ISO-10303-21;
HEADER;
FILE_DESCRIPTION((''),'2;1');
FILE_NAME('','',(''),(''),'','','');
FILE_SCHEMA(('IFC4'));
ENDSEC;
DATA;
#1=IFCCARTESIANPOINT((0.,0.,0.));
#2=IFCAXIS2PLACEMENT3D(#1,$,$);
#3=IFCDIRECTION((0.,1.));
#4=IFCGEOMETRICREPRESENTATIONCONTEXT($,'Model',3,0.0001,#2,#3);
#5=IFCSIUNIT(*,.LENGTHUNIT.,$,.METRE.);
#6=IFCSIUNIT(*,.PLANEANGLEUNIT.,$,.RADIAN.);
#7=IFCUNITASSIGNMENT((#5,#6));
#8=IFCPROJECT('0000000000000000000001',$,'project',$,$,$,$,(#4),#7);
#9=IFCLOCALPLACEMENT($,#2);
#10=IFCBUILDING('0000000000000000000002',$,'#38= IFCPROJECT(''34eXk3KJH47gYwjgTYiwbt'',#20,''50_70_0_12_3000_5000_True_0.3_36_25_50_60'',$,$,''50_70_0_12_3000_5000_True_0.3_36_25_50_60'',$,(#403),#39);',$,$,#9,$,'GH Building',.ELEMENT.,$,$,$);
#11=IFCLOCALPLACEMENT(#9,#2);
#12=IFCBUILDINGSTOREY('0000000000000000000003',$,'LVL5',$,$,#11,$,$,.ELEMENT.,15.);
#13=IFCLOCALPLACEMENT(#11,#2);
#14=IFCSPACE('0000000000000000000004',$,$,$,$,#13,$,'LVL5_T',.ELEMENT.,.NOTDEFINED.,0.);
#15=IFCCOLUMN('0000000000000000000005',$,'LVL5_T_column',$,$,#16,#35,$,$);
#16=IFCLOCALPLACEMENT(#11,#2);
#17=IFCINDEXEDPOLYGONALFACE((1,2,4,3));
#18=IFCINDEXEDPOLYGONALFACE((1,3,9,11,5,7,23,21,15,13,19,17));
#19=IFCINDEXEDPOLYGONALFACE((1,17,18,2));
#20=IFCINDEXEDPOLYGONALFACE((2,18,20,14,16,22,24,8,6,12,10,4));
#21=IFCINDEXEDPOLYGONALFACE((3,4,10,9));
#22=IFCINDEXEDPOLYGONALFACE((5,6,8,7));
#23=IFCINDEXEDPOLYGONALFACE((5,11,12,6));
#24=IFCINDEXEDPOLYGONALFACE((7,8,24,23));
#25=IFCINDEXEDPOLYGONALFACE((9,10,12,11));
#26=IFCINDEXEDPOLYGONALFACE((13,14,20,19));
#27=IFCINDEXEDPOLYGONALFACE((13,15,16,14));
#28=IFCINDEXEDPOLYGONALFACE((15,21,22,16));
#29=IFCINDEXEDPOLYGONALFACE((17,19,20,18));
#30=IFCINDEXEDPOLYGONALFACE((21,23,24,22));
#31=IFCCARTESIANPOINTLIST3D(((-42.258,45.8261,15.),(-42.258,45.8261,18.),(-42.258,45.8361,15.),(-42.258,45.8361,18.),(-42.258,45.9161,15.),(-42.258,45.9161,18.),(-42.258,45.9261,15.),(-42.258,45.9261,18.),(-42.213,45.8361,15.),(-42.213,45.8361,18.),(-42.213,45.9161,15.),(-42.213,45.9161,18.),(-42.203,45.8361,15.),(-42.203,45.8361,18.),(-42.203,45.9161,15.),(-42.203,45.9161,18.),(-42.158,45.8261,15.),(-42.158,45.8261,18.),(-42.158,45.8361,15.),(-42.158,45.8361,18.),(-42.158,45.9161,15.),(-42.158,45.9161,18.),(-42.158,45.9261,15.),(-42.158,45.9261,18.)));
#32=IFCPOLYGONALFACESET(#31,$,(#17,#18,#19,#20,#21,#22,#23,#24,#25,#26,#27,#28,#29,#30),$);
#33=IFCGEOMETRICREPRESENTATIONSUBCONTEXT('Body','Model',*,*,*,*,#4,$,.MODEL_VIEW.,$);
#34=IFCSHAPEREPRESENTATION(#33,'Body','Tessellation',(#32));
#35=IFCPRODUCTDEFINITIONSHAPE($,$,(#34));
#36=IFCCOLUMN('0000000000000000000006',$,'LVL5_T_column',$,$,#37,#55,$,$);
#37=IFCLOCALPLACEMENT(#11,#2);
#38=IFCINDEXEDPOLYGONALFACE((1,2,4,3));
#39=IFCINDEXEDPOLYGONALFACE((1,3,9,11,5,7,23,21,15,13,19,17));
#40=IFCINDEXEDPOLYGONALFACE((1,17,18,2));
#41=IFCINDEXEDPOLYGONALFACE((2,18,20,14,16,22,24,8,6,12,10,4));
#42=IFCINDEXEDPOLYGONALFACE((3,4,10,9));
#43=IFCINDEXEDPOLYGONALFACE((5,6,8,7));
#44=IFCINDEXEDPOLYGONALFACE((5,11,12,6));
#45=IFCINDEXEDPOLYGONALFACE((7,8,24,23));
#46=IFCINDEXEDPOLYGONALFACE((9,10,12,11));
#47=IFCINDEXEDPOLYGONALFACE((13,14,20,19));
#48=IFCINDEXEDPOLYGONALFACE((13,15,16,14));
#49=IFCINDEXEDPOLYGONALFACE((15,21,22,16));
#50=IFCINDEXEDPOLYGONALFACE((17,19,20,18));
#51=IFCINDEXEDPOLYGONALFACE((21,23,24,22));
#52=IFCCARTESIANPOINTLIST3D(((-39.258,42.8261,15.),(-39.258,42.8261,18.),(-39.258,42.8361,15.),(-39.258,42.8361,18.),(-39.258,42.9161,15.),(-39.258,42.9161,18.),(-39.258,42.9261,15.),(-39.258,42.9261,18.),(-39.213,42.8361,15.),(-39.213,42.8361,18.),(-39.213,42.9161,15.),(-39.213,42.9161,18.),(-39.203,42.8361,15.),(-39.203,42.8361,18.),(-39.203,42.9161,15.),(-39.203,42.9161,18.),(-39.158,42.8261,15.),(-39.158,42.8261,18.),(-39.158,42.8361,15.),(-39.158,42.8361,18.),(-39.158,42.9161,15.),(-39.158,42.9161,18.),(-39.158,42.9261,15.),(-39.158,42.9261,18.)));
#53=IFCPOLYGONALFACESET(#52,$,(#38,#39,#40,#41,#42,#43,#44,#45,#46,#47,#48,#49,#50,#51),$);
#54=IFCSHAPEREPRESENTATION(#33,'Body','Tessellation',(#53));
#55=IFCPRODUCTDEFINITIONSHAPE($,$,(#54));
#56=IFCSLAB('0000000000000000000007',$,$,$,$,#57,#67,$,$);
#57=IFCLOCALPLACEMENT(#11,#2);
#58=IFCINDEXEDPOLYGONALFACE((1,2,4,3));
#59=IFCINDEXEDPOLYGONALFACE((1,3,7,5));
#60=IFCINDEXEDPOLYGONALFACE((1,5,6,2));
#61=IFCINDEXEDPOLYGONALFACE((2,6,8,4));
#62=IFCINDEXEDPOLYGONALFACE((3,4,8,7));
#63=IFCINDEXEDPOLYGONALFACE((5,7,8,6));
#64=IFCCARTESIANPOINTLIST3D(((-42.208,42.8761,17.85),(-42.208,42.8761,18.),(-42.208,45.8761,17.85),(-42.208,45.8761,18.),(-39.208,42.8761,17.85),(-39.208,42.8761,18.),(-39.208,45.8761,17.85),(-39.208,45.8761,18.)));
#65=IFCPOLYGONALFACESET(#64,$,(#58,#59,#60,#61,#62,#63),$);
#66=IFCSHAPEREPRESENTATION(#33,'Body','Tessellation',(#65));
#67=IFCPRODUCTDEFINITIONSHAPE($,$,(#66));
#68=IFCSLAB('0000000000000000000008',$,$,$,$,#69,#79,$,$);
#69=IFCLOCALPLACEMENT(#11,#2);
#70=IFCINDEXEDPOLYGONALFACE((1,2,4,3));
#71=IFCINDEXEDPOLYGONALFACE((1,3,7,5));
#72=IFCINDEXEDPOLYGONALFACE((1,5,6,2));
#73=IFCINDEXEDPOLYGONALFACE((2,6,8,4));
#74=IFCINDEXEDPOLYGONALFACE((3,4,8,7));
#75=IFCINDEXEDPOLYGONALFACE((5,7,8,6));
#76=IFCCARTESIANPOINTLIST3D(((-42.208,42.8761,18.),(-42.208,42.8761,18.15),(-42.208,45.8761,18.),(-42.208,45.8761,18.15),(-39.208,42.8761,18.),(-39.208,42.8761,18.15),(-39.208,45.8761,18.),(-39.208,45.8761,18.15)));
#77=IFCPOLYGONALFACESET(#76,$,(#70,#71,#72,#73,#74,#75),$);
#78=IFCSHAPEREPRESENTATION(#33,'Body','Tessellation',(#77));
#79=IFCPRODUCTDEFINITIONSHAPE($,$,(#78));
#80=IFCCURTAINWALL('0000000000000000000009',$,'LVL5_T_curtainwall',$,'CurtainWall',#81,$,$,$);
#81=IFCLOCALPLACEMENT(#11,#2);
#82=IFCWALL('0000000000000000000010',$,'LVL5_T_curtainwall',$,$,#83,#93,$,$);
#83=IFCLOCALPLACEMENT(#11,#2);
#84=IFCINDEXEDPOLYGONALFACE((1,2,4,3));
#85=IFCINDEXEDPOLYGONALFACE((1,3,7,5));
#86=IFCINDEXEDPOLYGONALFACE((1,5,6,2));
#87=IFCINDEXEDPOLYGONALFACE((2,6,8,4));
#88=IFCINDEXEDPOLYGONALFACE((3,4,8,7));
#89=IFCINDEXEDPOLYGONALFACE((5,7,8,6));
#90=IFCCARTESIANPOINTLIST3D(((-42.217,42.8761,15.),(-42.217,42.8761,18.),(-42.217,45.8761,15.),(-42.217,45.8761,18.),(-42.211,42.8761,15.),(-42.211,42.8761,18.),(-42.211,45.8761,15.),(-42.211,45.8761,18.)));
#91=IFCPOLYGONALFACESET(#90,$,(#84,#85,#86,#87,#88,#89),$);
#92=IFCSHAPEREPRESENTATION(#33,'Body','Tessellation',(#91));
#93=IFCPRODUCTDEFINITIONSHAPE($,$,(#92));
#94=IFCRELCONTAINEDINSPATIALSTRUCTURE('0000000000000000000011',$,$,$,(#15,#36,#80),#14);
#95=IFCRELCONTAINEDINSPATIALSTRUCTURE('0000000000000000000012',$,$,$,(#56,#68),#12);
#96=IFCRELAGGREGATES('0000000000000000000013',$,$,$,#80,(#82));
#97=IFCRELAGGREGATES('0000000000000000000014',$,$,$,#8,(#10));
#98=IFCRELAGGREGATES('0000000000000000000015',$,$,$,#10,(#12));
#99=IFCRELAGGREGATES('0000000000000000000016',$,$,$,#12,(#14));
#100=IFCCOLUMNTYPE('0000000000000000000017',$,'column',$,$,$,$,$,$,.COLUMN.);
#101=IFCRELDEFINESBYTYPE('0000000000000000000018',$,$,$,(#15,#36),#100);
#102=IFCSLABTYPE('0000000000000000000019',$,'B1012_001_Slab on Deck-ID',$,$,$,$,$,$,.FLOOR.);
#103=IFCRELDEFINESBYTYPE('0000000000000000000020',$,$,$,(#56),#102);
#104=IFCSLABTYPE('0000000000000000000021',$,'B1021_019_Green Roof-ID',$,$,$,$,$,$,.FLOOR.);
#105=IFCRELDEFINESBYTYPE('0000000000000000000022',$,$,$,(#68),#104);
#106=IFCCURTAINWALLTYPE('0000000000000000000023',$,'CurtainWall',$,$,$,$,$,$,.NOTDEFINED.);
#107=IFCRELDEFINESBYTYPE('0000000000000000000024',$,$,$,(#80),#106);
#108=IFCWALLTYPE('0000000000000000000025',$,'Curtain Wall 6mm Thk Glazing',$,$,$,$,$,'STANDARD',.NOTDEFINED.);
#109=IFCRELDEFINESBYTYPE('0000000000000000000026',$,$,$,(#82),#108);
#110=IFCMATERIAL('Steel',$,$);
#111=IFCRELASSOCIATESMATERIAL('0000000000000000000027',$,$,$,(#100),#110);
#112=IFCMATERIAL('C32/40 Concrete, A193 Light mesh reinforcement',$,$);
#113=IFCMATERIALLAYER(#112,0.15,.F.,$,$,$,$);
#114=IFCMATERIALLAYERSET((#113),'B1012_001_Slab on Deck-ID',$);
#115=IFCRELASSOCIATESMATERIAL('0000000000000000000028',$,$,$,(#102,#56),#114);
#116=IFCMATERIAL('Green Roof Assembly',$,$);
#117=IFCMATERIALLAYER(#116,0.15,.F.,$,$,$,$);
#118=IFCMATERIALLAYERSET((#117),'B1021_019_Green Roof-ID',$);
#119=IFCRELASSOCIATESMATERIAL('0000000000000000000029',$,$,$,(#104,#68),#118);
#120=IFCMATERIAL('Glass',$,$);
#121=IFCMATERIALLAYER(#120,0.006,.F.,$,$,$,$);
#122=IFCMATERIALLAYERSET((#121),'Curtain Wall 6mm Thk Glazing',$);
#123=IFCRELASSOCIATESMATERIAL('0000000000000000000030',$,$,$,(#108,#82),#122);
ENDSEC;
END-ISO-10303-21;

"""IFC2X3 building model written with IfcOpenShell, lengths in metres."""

from ifc_helpers import new_model, si_unit, direction, frame, frame_2d, origin, origin_2d, place, context, subcontext, project, spatial, polyline, rectangle, i_section, outline, extrude, material, layer, layer_set, layer_usage, type_object, element, aggregate, save


model = new_model("IFC2X3")

# Units and contexts
model_context = context("Model", 3, precision=0.0001, world=origin(), true_north=direction((0.0, 1.0)))
body_context = subcontext(model_context, "Body", "Model", "MODEL_VIEW")
ifc_project = project(units=[si_unit("LENGTHUNIT", "METRE"), si_unit("PLANEANGLEUNIT", "RADIAN")], contexts=[model_context])

# Building, storey, space
building_placement = place(None, origin())
building = spatial("IfcBuilding", under=ifc_project, at=building_placement, Name="#38= IFCPROJECT('34eXk3KJH47gYwjgTYiwbt',#20,'50_70_0_12_3000_5000_True_0.3_36_25_50_60',$,$,'50_70_0_12_3000_5000_True_0.3_36_25_50_60',$,(#403),#39);", LongName="GH Building", CompositionType="ELEMENT")
storey_placement = place(building_placement, origin())
storey = spatial("IfcBuildingStorey", under=building, at=storey_placement, Name="LVL5", CompositionType="ELEMENT", Elevation=15.0)
space_1_placement = place(storey_placement, origin())
space_1 = spatial("IfcSpace", under=storey, at=space_1_placement, LongName="LVL5_T", CompositionType="ELEMENT", InteriorOrExteriorSpace="NOTDEFINED", ElevationWithFlooring=0.0)

# Columns
ifc_material_1 = material(Name="Steel")
column_type = type_object("IfcColumnType", Name="column", PredefinedType="COLUMN", material=ifc_material_1)
for number, where, name in (
    (1, (-42.208, 45.8761, 15.0), "LVL5_T_column"),
    (2, (-39.208, 42.8761, 15.0), "LVL5_T_column"),
):
    element("IfcColumn", number, at=place(space_1_placement, frame(where)), inside=space_1, type_object=column_type, Name=name, context=body_context, shape_type="SweptSolid", body=[
        extrude(i_section(OverallWidth=0.1, OverallDepth=0.1, WebThickness=0.01, FlangeThickness=0.01, at=origin_2d()), origin(), (0.0, 0.0, 1.0), 3.0),
    ])

# Slabs
ifc_material_2 = material(Name="C32/40 Concrete, A193 Light mesh reinforcement")
ifc_layer_1 = layer(ifc_material_2, 0.15, ventilated=False)
ifc_layer_set_1 = layer_set([ifc_layer_1], Name="B1012_001_Slab on Deck-ID")
ifc_layer_usage_1 = layer_usage(ifc_layer_set_1, "AXIS3", "NEGATIVE", -0.15)
slab_type_1 = type_object("IfcSlabType", Name="B1012_001_Slab on Deck-ID", PredefinedType="FLOOR", material=ifc_layer_set_1)
slab_1_placement = place(storey_placement, frame((-40.708, 44.3761, 17.85)))
element("IfcSlab", 3, at=slab_1_placement, inside=storey, type_object=slab_type_1, material=ifc_layer_usage_1, context=body_context, shape_type="SweptSolid", body=[
    extrude(outline(polyline([(-1.5, 1.5), (1.5, 1.5), (1.5, -1.5), (-1.5, -1.5), (-1.5, 1.5)])), origin(), (0.0, 0.0, 1.0), 0.15),
])
ifc_material_3 = material(Name="Green Roof Assembly")
ifc_layer_2 = layer(ifc_material_3, 0.15, ventilated=False)
ifc_layer_set_2 = layer_set([ifc_layer_2], Name="B1021_019_Green Roof-ID")
ifc_layer_usage_2 = layer_usage(ifc_layer_set_2, "AXIS3", "NEGATIVE", -0.15)
slab_type_2 = type_object("IfcSlabType", Name="B1021_019_Green Roof-ID", PredefinedType="FLOOR", material=ifc_layer_set_2)
slab_2_placement = place(storey_placement, frame((-40.708, 44.3761, 18.0)))
element("IfcSlab", 4, at=slab_2_placement, inside=storey, type_object=slab_type_2, material=ifc_layer_usage_2, context=body_context, shape_type="SweptSolid", body=[
    extrude(outline(polyline([(-1.5, 1.5), (1.5, 1.5), (1.5, -1.5), (-1.5, -1.5), (-1.5, 1.5)])), origin(), (0.0, 0.0, 1.0), 0.15),
])

# Curtain wall, wall
curtain_wall_type = type_object("IfcCurtainWallType", Name="CurtainWall", PredefinedType="NOTDEFINED")
curtain_wall_1_placement = place(None, origin())
curtain_wall_1 = element("IfcCurtainWall", 5, at=curtain_wall_1_placement, inside=space_1, type_object=curtain_wall_type, Name="LVL5_T_curtainwall", ObjectType="CurtainWall")
ifc_material_4 = material(Name="Glass")
ifc_layer_3 = layer(ifc_material_4, 0.006, ventilated=False)
ifc_layer_set_3 = layer_set([ifc_layer_3], Name="Curtain Wall 6mm Thk Glazing")
ifc_layer_usage_3 = layer_usage(ifc_layer_set_3, "AXIS2", "NEGATIVE", -0.003)
wall_type = type_object("IfcWallType", Name="Curtain Wall 6mm Thk Glazing", ElementType="STANDARD", PredefinedType="NOTDEFINED", material=ifc_layer_set_3)
wall_1_placement = place(curtain_wall_1_placement, frame((-42.208, 45.8761, 15.0), z_axis=(0.0, 0.0, 1.0), x_axis=(0.0, -1.0, 0.0)))
wall_1 = element("IfcWall", 6, at=wall_1_placement, type_object=wall_type, material=ifc_layer_usage_3, Name="LVL5_T_curtainwall", context=body_context, shape_type="SweptSolid", body=[
    extrude(rectangle(XDim=3.0, YDim=0.006, at=frame_2d((1.5, -0.006))), origin(), (0.0, 0.0, 1.0), 3.0),
])
aggregate(curtain_wall_1, [wall_1])

save(model, "model.ifc")
